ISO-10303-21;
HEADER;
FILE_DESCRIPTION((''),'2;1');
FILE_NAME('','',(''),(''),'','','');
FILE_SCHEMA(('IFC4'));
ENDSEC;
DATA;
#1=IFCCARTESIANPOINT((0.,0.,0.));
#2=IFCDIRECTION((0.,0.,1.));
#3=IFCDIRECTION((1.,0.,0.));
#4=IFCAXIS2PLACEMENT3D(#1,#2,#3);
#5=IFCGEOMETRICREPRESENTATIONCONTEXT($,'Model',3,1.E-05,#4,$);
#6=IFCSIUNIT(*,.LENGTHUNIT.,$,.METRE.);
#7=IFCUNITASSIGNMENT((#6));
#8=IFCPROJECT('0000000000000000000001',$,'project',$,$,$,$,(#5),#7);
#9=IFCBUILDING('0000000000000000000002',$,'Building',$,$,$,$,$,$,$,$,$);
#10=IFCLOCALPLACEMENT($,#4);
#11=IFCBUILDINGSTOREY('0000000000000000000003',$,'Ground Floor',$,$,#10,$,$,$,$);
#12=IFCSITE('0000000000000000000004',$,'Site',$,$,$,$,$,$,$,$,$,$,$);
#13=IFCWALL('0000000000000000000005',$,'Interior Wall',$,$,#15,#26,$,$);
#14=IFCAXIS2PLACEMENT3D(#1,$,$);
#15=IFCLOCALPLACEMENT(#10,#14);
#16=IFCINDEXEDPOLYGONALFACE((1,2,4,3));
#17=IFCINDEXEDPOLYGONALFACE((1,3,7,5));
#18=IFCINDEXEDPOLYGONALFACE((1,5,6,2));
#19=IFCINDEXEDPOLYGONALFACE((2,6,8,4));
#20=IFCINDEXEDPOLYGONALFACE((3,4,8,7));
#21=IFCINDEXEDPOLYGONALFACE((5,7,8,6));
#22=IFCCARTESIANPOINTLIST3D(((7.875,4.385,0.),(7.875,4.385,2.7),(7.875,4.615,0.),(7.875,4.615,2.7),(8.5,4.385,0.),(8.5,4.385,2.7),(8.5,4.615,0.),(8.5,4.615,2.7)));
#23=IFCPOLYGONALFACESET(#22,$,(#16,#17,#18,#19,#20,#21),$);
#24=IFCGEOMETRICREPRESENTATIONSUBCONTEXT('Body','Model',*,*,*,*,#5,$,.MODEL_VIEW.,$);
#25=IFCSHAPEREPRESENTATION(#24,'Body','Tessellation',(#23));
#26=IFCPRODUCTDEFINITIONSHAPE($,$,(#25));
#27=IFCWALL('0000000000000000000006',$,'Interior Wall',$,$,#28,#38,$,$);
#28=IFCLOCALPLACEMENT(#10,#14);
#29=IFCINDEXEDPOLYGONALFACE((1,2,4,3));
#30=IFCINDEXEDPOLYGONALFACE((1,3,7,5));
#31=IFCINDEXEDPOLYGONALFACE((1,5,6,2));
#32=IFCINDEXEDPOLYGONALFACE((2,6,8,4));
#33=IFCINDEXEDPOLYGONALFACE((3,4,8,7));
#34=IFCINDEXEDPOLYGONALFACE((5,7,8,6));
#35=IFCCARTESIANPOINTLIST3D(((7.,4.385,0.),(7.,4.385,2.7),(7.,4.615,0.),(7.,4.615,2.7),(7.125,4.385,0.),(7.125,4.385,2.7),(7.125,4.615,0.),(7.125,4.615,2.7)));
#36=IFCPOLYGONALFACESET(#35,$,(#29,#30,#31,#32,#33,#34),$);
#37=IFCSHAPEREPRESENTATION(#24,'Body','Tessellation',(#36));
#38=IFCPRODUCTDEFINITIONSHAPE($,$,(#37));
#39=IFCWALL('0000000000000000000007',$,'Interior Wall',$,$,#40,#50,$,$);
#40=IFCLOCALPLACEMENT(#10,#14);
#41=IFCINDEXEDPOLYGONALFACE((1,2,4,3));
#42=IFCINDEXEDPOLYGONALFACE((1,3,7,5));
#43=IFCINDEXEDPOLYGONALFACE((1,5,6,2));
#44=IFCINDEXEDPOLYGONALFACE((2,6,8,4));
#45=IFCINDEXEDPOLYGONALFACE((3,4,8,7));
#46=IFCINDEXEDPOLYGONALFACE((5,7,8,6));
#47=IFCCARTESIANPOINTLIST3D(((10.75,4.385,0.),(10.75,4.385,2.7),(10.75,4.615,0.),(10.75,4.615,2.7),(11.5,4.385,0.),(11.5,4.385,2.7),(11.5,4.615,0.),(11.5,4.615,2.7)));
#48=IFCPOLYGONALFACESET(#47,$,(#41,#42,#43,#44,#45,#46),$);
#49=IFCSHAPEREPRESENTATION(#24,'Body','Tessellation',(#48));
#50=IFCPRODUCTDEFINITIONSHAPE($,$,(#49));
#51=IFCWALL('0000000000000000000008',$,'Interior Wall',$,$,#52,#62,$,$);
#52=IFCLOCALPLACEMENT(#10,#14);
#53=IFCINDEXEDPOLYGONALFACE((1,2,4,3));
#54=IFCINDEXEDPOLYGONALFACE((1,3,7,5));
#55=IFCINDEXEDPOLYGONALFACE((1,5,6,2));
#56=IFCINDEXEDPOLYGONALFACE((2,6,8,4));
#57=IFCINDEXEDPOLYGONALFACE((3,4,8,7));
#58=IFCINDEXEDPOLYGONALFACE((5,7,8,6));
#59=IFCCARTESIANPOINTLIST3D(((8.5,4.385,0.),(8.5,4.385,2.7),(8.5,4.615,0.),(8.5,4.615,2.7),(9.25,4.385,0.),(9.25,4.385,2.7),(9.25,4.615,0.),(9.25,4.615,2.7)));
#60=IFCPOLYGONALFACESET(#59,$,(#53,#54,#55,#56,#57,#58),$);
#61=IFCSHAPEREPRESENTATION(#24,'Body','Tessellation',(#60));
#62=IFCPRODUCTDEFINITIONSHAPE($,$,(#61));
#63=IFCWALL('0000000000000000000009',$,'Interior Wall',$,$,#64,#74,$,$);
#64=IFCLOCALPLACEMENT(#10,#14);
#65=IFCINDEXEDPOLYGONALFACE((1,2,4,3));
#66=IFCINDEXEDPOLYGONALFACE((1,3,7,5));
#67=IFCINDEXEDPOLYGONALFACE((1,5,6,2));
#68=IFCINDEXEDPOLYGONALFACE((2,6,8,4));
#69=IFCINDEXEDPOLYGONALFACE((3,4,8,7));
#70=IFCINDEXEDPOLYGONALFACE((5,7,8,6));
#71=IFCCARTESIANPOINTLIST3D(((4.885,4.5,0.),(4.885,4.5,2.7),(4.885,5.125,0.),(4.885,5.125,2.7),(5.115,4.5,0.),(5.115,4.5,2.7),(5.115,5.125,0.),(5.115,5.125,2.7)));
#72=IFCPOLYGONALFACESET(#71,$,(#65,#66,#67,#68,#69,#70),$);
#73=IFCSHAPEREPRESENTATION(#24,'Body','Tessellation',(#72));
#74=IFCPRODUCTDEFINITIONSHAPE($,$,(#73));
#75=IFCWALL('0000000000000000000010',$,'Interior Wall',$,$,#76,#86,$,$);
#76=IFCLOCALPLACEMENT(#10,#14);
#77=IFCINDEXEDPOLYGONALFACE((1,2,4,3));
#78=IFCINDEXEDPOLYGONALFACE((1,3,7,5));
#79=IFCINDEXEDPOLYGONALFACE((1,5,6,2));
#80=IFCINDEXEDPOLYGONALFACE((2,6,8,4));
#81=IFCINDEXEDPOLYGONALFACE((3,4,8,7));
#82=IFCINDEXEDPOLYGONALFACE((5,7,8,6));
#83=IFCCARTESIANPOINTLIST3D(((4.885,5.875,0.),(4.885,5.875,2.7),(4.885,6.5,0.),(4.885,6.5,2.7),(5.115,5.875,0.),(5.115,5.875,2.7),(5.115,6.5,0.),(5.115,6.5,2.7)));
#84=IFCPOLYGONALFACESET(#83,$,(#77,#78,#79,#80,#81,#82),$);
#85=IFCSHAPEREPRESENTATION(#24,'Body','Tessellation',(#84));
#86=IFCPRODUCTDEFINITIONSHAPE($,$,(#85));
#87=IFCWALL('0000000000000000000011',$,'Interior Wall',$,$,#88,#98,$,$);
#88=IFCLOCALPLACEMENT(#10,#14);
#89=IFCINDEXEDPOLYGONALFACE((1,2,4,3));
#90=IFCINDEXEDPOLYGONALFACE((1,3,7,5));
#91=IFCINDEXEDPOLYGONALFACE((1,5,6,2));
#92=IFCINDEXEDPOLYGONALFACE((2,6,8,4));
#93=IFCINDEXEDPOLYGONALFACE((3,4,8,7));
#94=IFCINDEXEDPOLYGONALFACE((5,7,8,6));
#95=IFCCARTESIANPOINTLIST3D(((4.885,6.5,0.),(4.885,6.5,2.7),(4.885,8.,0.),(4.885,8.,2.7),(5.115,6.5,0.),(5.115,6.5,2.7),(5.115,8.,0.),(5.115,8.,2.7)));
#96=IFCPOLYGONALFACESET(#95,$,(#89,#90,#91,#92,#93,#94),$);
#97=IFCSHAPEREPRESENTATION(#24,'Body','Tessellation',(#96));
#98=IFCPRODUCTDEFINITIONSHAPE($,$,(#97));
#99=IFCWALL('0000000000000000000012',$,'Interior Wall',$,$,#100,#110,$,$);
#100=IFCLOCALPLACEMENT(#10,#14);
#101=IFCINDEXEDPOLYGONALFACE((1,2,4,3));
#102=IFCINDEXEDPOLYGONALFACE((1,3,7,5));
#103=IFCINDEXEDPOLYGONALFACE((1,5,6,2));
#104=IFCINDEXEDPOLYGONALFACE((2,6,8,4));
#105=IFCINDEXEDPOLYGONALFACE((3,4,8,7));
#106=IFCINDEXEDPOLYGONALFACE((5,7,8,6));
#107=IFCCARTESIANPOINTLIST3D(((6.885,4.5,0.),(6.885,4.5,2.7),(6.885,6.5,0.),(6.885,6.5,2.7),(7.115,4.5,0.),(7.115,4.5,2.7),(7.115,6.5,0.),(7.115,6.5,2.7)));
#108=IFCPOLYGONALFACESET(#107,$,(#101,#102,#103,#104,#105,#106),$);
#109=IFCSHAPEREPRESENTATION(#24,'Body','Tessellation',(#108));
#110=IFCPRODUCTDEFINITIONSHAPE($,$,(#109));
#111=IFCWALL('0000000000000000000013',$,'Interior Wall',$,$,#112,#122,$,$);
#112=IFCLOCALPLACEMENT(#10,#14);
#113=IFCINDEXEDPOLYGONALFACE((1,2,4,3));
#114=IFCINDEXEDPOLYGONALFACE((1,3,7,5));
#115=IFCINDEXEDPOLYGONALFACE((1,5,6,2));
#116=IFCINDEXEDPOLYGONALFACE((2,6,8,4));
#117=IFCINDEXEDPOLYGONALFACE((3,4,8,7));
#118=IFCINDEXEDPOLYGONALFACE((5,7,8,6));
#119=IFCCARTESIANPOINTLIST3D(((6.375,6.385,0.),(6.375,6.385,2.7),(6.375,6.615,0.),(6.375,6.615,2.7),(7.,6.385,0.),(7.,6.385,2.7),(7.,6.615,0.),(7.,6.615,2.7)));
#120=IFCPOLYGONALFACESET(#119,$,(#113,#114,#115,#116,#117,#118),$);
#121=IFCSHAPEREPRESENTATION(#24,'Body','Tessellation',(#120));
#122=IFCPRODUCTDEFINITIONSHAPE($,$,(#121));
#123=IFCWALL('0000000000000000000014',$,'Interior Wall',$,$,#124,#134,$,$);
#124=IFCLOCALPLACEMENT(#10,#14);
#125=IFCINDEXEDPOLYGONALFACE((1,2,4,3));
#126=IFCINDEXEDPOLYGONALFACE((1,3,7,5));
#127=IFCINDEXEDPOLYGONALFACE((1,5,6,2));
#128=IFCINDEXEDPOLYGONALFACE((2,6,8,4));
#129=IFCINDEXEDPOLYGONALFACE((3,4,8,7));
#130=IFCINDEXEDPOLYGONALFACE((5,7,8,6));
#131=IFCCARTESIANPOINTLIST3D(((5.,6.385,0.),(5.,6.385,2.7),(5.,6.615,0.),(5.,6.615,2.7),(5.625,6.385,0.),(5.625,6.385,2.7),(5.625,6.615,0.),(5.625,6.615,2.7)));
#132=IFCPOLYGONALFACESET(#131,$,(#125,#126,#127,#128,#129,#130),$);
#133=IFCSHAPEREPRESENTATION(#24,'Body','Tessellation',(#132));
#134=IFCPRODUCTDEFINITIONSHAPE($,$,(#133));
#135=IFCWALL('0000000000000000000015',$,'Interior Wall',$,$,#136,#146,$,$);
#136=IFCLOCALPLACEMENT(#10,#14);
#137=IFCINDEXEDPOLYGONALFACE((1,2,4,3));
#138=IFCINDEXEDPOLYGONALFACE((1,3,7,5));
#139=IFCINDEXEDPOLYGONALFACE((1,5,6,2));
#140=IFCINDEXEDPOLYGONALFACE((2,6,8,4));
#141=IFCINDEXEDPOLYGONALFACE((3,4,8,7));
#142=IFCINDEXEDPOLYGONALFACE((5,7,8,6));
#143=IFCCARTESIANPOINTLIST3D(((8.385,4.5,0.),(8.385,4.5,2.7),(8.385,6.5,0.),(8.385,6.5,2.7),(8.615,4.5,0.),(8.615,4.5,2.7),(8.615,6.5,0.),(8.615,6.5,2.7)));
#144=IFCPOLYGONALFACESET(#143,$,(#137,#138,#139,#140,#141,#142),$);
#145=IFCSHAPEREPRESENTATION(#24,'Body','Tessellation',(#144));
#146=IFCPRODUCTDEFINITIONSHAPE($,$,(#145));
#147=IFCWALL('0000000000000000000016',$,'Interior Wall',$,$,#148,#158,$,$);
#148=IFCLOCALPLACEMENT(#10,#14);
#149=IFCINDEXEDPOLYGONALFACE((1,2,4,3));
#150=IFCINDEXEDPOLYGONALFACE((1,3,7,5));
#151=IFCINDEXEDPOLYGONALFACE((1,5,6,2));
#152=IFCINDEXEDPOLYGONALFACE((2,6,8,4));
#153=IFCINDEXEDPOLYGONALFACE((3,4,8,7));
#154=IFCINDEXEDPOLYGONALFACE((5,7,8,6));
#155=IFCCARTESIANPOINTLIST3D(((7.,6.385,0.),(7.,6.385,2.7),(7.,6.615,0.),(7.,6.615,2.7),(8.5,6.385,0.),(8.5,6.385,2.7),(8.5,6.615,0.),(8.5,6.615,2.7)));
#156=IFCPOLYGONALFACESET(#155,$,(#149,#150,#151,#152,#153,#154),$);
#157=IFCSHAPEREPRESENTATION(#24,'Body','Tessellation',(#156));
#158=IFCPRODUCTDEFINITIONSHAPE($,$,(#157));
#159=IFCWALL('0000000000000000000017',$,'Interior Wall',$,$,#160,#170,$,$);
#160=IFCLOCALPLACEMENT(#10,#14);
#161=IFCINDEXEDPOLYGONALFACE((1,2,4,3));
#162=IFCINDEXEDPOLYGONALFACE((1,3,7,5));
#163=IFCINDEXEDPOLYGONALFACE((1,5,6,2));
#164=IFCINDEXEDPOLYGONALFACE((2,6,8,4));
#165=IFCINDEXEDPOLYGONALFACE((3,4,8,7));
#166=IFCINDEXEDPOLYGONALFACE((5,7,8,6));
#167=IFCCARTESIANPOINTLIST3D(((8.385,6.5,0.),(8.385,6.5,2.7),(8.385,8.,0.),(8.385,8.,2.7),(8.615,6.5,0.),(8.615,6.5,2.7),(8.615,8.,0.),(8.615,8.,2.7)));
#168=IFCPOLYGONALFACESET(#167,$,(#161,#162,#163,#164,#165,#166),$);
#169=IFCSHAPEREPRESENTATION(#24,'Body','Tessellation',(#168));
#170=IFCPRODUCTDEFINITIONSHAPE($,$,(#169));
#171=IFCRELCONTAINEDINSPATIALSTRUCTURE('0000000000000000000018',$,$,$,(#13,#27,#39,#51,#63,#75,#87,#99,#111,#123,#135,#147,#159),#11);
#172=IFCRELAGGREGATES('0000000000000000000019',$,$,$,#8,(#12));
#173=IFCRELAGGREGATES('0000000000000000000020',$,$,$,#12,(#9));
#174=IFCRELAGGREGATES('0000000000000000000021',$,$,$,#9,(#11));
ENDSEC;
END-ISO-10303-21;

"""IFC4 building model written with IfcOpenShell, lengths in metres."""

from ifc_helpers import new_model, si_unit, frame, origin_with_axes, place, context, subcontext, project, spatial, indexed_curve, outline, extrude, element, save


model = new_model("IFC4")

# Units and contexts
model_context = context("Model", 3, precision=1e-05, world=origin_with_axes())
body_context = subcontext(model_context, "Body", "Model", "MODEL_VIEW")
ifc_project = project(units=[si_unit("LENGTHUNIT", "METRE")], contexts=[model_context])

# Site, building, storey
site = spatial("IfcSite", under=ifc_project, Name="Site")
building = spatial("IfcBuilding", under=site, Name="Building")
storey_placement = place(None, origin_with_axes())
storey = spatial("IfcBuildingStorey", under=building, at=storey_placement, Name="Ground Floor")

# Walls
wall_1_placement = place(storey_placement, frame((8.5, 4.5, 0.0), z_axis=(0.0, 0.0, 1.0), x_axis=(-1.0, 0.0, 0.0)))
element("IfcWall", 1, at=wall_1_placement, inside=storey, Name="Interior Wall", context=body_context, shape_type="SweptSolid", body=[
    extrude(outline(indexed_curve([(0.0, 0.0), (0.0, 0.23), (0.625, 0.23), (0.625, 0.0), (0.0, 0.0)], self_intersect=False)), frame((0.0, -0.115, 0.0), z_axis=(0.0, 0.0, 1.0), x_axis=(1.0, 0.0, 0.0)), (0.0, 0.0, 1.0), 2.7),
])
wall_2_placement = place(storey_placement, frame((7.125, 4.5, 0.0), z_axis=(0.0, 0.0, 1.0), x_axis=(-1.0, 0.0, 0.0)))
element("IfcWall", 2, at=wall_2_placement, inside=storey, Name="Interior Wall", context=body_context, shape_type="SweptSolid", body=[
    extrude(outline(indexed_curve([(0.0, 0.0), (0.0, 0.23), (0.125, 0.23), (0.125, 0.0), (0.0, 0.0)], self_intersect=False)), frame((0.0, -0.115, 0.0), z_axis=(0.0, 0.0, 1.0), x_axis=(1.0, 0.0, 0.0)), (0.0, 0.0, 1.0), 2.7),
])
for number, where, z_axis, x_axis, name in (
    (3, (11.5, 4.5, 0.0), (0.0, 0.0, 1.0), (-1.0, 0.0, 0.0), "Interior Wall"),
    (4, (9.25, 4.5, 0.0), (0.0, 0.0, 1.0), (-1.0, 0.0, 0.0), "Interior Wall"),
):
    element("IfcWall", number, at=place(storey_placement, frame(where, z_axis=z_axis, x_axis=x_axis)), inside=storey, Name=name, context=body_context, shape_type="SweptSolid", body=[
        extrude(outline(indexed_curve([(0.0, 0.0), (0.0, 0.23), (0.75, 0.23), (0.75, 0.0), (0.0, 0.0)], self_intersect=False)), frame((0.0, -0.115, 0.0), z_axis=(0.0, 0.0, 1.0), x_axis=(1.0, 0.0, 0.0)), (0.0, 0.0, 1.0), 2.7),
    ])
for number, where, z_axis, x_axis, name in (
    (5, (5.0, 4.5, 0.0), (0.0, 0.0, 1.0), (0.0, 1.0, 0.0), "Interior Wall"),
    (6, (5.0, 5.875, 0.0), (0.0, 0.0, 1.0), (0.0, 1.0, 0.0), "Interior Wall"),
):
    element("IfcWall", number, at=place(storey_placement, frame(where, z_axis=z_axis, x_axis=x_axis)), inside=storey, Name=name, context=body_context, shape_type="SweptSolid", body=[
        extrude(outline(indexed_curve([(0.0, 0.0), (0.0, 0.23), (0.625, 0.23), (0.625, 0.0), (0.0, 0.0)], self_intersect=False)), frame((0.0, -0.115, 0.0), z_axis=(0.0, 0.0, 1.0), x_axis=(1.0, 0.0, 0.0)), (0.0, 0.0, 1.0), 2.7),
    ])
wall_3_placement = place(storey_placement, frame((5.0, 6.5, 0.0), z_axis=(0.0, 0.0, 1.0), x_axis=(0.0, 1.0, 0.0)))
element("IfcWall", 7, at=wall_3_placement, inside=storey, Name="Interior Wall", context=body_context, shape_type="SweptSolid", body=[
    extrude(outline(indexed_curve([(0.0, 0.0), (0.0, 0.23), (1.5, 0.23), (1.5, 0.0), (0.0, 0.0)], self_intersect=False)), frame((0.0, -0.115, 0.0), z_axis=(0.0, 0.0, 1.0), x_axis=(1.0, 0.0, 0.0)), (0.0, 0.0, 1.0), 2.7),
])
wall_4_placement = place(storey_placement, frame((7.0, 4.5, 0.0), z_axis=(0.0, 0.0, 1.0), x_axis=(0.0, 1.0, 0.0)))
element("IfcWall", 8, at=wall_4_placement, inside=storey, Name="Interior Wall", context=body_context, shape_type="SweptSolid", body=[
    extrude(outline(indexed_curve([(0.0, 0.0), (0.0, 0.23), (2.0, 0.23), (2.0, 0.0), (0.0, 0.0)], self_intersect=False)), frame((0.0, -0.115, 0.0), z_axis=(0.0, 0.0, 1.0), x_axis=(1.0, 0.0, 0.0)), (0.0, 0.0, 1.0), 2.7),
])
for number, where, z_axis, x_axis, name in (
    (9, (7.0, 6.5, 0.0), (0.0, 0.0, 1.0), (-1.0, 0.0, 0.0), "Interior Wall"),
    (10, (5.625, 6.5, 0.0), (0.0, 0.0, 1.0), (-1.0, 0.0, 0.0), "Interior Wall"),
):
    element("IfcWall", number, at=place(storey_placement, frame(where, z_axis=z_axis, x_axis=x_axis)), inside=storey, Name=name, context=body_context, shape_type="SweptSolid", body=[
        extrude(outline(indexed_curve([(0.0, 0.0), (0.0, 0.23), (0.625, 0.23), (0.625, 0.0), (0.0, 0.0)], self_intersect=False)), frame((0.0, -0.115, 0.0), z_axis=(0.0, 0.0, 1.0), x_axis=(1.0, 0.0, 0.0)), (0.0, 0.0, 1.0), 2.7),
    ])
wall_5_placement = place(storey_placement, frame((8.5, 4.5, 0.0), z_axis=(0.0, 0.0, 1.0), x_axis=(0.0, 1.0, 0.0)))
element("IfcWall", 11, at=wall_5_placement, inside=storey, Name="Interior Wall", context=body_context, shape_type="SweptSolid", body=[
    extrude(outline(indexed_curve([(0.0, 0.0), (0.0, 0.23), (2.0, 0.23), (2.0, 0.0), (0.0, 0.0)], self_intersect=False)), frame((0.0, -0.115, 0.0), z_axis=(0.0, 0.0, 1.0), x_axis=(1.0, 0.0, 0.0)), (0.0, 0.0, 1.0), 2.7),
])
for number, where, z_axis, x_axis, name in (
    (12, (8.5, 6.5, 0.0), (0.0, 0.0, 1.0), (-1.0, 0.0, 0.0), "Interior Wall"),
    (13, (8.5, 6.5, 0.0), (0.0, 0.0, 1.0), (0.0, 1.0, 0.0), "Interior Wall"),
):
    element("IfcWall", number, at=place(storey_placement, frame(where, z_axis=z_axis, x_axis=x_axis)), inside=storey, Name=name, context=body_context, shape_type="SweptSolid", body=[
        extrude(outline(indexed_curve([(0.0, 0.0), (0.0, 0.23), (1.5, 0.23), (1.5, 0.0), (0.0, 0.0)], self_intersect=False)), frame((0.0, -0.115, 0.0), z_axis=(0.0, 0.0, 1.0), x_axis=(1.0, 0.0, 0.0)), (0.0, 0.0, 1.0), 2.7),
    ])

save(model, "model.ifc")
